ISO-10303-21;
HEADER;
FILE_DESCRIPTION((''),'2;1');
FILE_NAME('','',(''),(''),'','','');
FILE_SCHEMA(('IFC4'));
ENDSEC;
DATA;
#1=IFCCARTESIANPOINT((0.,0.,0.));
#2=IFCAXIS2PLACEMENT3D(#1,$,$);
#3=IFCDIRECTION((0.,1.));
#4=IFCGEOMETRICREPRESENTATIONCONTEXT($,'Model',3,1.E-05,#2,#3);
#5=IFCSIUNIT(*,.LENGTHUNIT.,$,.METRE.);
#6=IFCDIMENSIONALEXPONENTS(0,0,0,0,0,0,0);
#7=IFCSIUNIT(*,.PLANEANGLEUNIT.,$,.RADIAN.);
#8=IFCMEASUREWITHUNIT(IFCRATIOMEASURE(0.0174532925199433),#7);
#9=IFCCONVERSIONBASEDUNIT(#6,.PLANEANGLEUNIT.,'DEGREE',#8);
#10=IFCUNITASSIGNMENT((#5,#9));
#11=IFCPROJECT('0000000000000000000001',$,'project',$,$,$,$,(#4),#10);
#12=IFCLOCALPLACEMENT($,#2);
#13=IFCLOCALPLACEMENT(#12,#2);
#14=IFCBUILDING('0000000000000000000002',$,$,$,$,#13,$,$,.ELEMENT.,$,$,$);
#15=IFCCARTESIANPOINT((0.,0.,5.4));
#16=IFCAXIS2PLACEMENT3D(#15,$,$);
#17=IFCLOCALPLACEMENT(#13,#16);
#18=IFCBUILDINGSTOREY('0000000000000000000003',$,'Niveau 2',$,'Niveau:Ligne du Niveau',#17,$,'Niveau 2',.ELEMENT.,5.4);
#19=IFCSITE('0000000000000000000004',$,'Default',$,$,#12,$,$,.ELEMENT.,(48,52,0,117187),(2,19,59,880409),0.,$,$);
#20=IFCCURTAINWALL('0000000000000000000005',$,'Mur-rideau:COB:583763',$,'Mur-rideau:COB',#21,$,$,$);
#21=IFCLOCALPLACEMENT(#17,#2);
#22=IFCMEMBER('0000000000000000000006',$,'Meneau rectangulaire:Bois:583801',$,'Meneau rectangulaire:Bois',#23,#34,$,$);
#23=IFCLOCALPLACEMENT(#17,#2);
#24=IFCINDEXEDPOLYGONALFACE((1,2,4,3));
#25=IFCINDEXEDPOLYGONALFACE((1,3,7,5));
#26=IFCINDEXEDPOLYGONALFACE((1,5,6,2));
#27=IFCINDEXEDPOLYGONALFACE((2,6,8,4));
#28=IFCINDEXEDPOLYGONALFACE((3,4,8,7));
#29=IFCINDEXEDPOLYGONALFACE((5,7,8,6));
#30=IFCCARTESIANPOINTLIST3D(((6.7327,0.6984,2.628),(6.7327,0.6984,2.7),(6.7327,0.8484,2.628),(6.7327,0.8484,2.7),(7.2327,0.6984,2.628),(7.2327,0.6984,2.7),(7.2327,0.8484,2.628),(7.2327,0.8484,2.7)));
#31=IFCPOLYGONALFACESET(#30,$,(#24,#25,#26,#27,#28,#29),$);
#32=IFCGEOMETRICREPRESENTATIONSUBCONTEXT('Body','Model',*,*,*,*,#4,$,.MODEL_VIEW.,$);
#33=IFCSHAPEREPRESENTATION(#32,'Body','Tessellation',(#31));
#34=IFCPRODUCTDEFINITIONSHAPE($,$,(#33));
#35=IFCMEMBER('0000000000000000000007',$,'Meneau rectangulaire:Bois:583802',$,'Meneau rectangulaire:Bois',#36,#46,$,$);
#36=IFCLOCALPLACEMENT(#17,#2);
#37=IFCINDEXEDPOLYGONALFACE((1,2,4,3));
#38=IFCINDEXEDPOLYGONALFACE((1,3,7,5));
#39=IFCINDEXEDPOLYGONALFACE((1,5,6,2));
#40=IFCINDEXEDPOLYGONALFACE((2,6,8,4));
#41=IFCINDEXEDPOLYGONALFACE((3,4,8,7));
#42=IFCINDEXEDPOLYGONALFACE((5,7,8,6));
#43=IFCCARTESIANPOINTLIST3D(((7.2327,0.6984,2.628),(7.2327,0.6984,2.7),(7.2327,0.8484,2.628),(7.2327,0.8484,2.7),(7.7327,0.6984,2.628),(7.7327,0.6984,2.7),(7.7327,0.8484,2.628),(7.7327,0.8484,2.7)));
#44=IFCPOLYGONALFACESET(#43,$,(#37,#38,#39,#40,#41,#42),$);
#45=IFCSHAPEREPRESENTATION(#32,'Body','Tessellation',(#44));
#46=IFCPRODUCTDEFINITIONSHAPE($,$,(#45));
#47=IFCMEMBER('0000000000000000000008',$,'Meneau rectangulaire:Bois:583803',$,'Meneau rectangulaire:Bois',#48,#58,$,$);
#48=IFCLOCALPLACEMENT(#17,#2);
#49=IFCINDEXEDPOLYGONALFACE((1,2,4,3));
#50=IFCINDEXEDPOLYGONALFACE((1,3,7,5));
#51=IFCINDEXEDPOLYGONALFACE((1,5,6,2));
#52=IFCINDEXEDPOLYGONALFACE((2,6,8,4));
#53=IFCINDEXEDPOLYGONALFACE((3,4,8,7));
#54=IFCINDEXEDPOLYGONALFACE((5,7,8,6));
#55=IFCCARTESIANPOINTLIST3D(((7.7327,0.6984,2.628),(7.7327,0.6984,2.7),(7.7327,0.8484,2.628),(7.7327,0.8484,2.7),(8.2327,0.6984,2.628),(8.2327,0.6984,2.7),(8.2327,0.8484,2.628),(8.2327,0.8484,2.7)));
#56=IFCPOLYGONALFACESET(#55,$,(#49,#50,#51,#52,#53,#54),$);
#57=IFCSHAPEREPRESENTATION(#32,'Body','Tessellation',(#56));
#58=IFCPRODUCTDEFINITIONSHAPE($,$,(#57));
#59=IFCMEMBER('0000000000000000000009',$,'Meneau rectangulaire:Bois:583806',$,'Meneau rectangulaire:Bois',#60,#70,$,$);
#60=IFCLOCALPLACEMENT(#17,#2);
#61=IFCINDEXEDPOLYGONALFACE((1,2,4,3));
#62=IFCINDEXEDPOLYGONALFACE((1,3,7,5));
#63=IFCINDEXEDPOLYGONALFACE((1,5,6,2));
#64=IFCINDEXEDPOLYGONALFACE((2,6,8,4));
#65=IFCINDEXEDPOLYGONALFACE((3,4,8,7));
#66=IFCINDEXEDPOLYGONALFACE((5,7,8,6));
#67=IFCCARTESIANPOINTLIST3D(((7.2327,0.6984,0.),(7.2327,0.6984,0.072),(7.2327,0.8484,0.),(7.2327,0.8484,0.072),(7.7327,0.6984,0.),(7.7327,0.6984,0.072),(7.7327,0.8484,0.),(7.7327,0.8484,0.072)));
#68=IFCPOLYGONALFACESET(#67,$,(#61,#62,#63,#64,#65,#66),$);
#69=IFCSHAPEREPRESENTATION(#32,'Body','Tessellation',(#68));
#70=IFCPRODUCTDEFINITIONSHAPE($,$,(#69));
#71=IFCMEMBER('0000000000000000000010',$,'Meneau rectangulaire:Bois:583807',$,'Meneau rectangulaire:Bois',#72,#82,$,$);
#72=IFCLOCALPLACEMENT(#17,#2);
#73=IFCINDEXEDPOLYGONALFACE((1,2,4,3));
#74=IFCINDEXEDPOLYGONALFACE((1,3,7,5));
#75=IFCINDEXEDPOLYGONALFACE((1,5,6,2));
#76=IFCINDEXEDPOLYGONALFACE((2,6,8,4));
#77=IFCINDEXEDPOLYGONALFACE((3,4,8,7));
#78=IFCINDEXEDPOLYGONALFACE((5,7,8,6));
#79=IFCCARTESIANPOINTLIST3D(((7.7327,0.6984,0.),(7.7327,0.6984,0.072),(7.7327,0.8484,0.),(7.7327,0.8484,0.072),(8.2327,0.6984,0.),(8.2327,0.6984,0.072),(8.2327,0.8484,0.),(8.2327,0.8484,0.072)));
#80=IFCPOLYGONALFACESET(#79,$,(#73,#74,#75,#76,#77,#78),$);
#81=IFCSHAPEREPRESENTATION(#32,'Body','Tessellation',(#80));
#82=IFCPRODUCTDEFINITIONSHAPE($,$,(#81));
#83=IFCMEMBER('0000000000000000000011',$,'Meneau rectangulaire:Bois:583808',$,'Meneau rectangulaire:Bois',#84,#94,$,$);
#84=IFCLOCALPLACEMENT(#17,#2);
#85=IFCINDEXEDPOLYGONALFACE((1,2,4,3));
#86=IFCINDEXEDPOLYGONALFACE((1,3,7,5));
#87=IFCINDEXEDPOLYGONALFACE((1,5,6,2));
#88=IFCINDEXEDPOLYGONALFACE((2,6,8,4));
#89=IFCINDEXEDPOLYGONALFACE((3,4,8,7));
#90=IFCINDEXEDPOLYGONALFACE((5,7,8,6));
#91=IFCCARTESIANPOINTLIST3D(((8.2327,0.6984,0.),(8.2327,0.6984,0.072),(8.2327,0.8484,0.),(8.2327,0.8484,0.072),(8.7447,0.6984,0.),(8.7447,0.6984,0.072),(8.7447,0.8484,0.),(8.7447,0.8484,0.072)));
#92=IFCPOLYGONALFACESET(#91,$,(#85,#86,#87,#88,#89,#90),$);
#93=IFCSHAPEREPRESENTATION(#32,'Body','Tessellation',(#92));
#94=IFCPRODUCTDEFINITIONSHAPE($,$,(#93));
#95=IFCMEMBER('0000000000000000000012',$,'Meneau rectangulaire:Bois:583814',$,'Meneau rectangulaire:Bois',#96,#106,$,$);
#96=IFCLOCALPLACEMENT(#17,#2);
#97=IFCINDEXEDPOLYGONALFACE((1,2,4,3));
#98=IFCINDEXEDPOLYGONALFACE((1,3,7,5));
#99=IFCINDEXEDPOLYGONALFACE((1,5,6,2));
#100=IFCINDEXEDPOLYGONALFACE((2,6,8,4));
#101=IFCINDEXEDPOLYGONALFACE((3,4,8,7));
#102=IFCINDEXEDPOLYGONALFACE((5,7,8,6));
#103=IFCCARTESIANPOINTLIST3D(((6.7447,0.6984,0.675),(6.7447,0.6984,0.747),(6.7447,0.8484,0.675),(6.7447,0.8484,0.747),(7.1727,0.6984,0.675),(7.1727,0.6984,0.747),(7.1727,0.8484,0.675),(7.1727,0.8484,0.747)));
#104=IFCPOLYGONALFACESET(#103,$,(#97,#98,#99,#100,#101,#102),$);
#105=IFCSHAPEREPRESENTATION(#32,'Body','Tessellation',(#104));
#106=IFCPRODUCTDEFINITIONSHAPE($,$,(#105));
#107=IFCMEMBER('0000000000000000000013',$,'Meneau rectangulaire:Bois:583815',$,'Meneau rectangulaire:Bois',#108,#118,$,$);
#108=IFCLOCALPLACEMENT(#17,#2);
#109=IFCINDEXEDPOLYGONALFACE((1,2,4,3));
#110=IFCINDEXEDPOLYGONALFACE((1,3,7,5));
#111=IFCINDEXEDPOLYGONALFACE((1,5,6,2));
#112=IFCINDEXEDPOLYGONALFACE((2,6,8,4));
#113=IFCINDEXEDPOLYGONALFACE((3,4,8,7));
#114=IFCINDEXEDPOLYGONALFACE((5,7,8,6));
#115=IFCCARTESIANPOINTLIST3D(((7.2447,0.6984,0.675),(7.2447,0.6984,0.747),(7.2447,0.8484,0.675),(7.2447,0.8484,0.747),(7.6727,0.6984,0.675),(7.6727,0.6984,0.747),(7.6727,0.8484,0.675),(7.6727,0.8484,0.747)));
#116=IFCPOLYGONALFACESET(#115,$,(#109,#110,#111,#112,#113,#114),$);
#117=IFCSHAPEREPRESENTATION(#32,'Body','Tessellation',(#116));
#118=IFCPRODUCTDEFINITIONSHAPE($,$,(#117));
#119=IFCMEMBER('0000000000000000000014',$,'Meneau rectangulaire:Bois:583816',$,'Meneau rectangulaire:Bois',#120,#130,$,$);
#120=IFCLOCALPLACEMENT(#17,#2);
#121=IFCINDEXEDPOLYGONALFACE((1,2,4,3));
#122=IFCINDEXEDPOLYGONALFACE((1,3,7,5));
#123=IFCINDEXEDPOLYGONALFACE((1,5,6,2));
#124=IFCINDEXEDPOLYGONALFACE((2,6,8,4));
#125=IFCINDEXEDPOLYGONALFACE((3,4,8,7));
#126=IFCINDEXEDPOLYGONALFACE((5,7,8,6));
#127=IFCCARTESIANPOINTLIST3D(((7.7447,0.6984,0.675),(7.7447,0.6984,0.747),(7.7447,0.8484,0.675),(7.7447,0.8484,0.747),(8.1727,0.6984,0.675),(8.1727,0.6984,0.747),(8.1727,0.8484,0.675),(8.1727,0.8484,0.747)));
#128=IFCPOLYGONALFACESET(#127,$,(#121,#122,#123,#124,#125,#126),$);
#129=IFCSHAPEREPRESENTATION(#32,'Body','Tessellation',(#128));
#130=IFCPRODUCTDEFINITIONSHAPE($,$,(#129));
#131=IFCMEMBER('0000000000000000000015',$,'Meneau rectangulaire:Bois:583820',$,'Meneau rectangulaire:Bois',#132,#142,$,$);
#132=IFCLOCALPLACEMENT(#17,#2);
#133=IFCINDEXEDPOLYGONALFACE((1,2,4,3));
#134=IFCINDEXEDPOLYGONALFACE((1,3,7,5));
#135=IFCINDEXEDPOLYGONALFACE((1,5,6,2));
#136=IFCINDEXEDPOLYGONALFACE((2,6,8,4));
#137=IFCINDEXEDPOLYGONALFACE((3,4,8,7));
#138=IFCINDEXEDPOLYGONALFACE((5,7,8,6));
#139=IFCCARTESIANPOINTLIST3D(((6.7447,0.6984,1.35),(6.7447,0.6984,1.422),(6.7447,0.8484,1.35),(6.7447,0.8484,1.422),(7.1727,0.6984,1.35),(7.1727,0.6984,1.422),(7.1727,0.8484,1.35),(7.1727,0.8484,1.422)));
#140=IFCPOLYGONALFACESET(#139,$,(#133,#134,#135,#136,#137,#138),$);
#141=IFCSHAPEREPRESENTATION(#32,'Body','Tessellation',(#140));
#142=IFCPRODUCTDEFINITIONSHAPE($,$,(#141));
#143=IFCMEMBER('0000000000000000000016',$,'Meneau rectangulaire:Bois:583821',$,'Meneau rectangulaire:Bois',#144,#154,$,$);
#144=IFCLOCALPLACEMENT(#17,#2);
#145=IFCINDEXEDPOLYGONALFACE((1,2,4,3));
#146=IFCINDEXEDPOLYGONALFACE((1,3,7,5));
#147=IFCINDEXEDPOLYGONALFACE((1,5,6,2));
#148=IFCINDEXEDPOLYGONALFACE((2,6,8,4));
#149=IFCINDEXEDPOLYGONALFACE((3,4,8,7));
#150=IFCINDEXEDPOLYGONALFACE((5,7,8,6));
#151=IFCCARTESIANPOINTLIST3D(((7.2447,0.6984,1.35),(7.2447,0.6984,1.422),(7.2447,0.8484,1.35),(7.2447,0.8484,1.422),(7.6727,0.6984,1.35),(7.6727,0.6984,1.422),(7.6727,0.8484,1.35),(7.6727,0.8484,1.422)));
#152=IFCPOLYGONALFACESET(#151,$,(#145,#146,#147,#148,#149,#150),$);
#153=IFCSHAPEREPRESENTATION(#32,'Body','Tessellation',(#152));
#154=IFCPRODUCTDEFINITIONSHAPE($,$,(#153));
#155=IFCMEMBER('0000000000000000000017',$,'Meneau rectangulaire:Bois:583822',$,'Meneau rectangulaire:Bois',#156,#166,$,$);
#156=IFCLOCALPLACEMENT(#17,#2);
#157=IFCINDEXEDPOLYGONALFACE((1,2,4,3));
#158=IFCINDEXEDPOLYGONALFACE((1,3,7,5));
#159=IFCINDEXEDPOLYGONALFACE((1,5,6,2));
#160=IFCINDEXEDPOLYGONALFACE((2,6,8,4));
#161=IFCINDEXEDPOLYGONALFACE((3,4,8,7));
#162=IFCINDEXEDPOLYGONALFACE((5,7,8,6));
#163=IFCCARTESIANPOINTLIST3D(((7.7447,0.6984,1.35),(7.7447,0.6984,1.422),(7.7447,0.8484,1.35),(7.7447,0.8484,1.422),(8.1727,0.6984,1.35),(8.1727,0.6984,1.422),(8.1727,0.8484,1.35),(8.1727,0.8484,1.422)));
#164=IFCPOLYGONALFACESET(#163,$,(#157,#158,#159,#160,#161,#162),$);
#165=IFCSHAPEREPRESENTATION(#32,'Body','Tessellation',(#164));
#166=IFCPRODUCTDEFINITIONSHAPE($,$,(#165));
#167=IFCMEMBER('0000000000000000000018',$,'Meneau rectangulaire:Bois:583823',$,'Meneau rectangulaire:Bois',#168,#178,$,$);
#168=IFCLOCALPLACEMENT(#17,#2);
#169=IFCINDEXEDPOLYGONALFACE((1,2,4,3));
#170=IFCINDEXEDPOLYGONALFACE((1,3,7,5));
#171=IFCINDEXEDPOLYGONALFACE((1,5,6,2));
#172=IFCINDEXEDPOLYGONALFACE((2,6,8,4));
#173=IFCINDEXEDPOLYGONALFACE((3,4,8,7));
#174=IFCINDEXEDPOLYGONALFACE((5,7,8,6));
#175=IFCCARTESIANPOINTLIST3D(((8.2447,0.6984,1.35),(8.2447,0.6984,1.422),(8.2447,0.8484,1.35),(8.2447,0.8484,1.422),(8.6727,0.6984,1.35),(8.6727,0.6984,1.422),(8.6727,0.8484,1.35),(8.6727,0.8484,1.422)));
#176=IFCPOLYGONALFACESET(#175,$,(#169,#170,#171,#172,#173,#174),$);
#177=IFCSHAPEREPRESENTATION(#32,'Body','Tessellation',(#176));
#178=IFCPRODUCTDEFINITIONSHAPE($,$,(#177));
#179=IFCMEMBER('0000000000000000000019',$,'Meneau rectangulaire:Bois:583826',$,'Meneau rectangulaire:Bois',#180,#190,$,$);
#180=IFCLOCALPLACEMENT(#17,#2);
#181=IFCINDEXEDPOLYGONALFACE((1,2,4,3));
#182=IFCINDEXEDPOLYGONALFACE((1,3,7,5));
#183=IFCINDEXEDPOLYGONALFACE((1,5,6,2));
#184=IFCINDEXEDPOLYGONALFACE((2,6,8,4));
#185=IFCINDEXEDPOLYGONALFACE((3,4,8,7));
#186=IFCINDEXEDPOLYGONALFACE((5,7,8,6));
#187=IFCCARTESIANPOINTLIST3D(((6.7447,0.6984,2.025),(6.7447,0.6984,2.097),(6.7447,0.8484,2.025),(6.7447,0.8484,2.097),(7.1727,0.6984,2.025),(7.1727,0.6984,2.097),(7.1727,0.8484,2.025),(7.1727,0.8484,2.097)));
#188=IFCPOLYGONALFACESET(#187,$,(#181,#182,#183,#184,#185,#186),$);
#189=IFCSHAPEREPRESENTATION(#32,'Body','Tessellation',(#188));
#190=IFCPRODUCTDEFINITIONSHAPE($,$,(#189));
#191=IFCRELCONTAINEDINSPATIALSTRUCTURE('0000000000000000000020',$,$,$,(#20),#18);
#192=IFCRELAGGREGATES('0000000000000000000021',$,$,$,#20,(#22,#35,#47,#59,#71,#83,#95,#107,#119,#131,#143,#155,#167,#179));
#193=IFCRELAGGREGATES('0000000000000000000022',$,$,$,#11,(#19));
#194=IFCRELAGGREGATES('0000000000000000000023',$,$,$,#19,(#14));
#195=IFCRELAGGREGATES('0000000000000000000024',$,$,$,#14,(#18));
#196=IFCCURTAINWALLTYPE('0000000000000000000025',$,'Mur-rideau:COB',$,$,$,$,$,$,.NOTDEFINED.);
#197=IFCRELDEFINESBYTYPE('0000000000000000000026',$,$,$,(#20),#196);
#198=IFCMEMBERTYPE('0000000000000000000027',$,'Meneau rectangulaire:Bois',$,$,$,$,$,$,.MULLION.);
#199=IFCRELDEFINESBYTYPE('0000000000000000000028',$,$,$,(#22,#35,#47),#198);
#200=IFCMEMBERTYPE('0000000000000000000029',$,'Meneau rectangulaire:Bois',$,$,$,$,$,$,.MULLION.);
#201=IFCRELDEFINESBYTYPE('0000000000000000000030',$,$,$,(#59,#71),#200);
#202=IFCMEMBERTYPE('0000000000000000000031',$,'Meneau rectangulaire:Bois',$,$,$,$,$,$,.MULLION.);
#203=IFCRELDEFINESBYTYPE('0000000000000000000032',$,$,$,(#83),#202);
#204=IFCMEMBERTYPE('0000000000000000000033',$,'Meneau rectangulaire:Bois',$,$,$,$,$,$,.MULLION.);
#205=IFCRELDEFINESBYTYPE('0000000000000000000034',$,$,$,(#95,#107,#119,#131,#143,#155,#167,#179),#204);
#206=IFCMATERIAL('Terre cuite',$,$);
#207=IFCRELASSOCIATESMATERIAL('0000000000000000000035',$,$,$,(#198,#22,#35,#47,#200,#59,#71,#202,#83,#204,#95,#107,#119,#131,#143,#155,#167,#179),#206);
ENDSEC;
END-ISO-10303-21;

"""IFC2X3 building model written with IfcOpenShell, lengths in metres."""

from ifc_helpers import new_model, entity, si_unit, converted_unit, direction, frame, origin, origin_2d_with_axis, place, context, subcontext, project, spatial, rectangle, extrude, source, transform, mapped, material, type_object, type_shapes, element, aggregate, save


model = new_model("IFC2X3")

# Units and contexts
model_context = context("Model", 3, precision=1e-05, world=origin(), true_north=direction((0.0, 1.0)))
body_context = subcontext(model_context, "Body", "Model", "MODEL_VIEW")
ifc_project = project(units=[si_unit("LENGTHUNIT", "METRE"), converted_unit("PLANEANGLEUNIT", "DEGREE", entity("IfcRatioMeasure", 0.0174532925199433), si_unit("PLANEANGLEUNIT", "RADIAN"), dimensions=[0, 0, 0, 0, 0, 0, 0])], contexts=[model_context])

# Site, building, storey
site_placement = place(None, origin())
site = spatial("IfcSite", under=ifc_project, at=site_placement, Name="Default", CompositionType="ELEMENT", RefLatitude=(48, 52, 0, 117187), RefLongitude=(2, 19, 59, 880409), RefElevation=0.0)
building_placement = place(site_placement, origin())
building = spatial("IfcBuilding", under=site, at=building_placement, CompositionType="ELEMENT")
storey_placement = place(building_placement, frame((0.0, 0.0, 5.4)))
storey = spatial("IfcBuildingStorey", under=building, at=storey_placement, Name="Niveau 2", ObjectType="Niveau:Ligne du Niveau", LongName="Niveau 2", CompositionType="ELEMENT", Elevation=5.4)

# Curtain wall, members
curtain_wall_type_1 = type_object("IfcCurtainWallType", Name="Mur-rideau:COB", PredefinedType="NOTDEFINED")
curtain_wall_1_placement = place(storey_placement, frame((0.0, 0.0, -5.4)))
curtain_wall_1 = element("IfcCurtainWall", 1, at=curtain_wall_1_placement, inside=storey, type_object=curtain_wall_type_1, Name="Mur-rideau:COB:583763", ObjectType="Mur-rideau:COB")
ifc_material_1 = material(Name="Terre cuite")
member_type_1 = type_object("IfcMemberType", Name="Meneau rectangulaire:Bois", PredefinedType="MULLION", material=ifc_material_1)
shared_shape_1 = source(origin(), body_context, "Body", "SweptSolid", [
    extrude(rectangle(XDim=0.15, YDim=0.072, at=origin_2d_with_axis()), frame((-0.036, 0.0, -0.5), z_axis=(0.0, 0.0, 1.0), x_axis=(0.0, -1.0, 0.0)), (0.0, 0.0, 1.0), 0.5),
])
type_shapes(member_type_1, [shared_shape_1])
member_1_placement = place(storey_placement, frame((7.2327, 0.7734, 2.7), z_axis=(1.0, 0.0, 0.0), x_axis=(0.0, 0.0, 1.0)))
member_1 = element("IfcMember", 2, at=member_1_placement, type_object=member_type_1, material=ifc_material_1, Name="Meneau rectangulaire:Bois:583801", ObjectType="Meneau rectangulaire:Bois", context=body_context, shape_type="MappedRepresentation", body=[
    mapped(shared_shape_1, transform((0.0, 0.0, 0.0), scale=1.0)),
])
member_2_placement = place(storey_placement, frame((7.7327, 0.7734, 2.7), z_axis=(1.0, 0.0, 0.0), x_axis=(0.0, 0.0, 1.0)))
member_2 = element("IfcMember", 3, at=member_2_placement, type_object=member_type_1, material=ifc_material_1, Name="Meneau rectangulaire:Bois:583802", ObjectType="Meneau rectangulaire:Bois", context=body_context, shape_type="MappedRepresentation", body=[
    mapped(shared_shape_1, transform((0.0, 0.0, 0.0), scale=1.0)),
])
member_3_placement = place(storey_placement, frame((8.2327, 0.7734, 2.7), z_axis=(1.0, 0.0, 0.0), x_axis=(0.0, 0.0, 1.0)))
member_3 = element("IfcMember", 4, at=member_3_placement, type_object=member_type_1, material=ifc_material_1, Name="Meneau rectangulaire:Bois:583803", ObjectType="Meneau rectangulaire:Bois", context=body_context, shape_type="MappedRepresentation", body=[
    mapped(shared_shape_1, transform((0.0, 0.0, 0.0), scale=1.0)),
])
member_type_2 = type_object("IfcMemberType", Name="Meneau rectangulaire:Bois", PredefinedType="MULLION", material=ifc_material_1)
shared_shape_2 = source(origin(), body_context, "Body", "SweptSolid", [
    extrude(rectangle(XDim=0.15, YDim=0.072, at=origin_2d_with_axis()), frame((-0.036, 0.0, -0.5), z_axis=(0.0, 0.0, 1.0), x_axis=(0.0, -1.0, 0.0)), (0.0, 0.0, 1.0), 0.5),
])
type_shapes(member_type_2, [shared_shape_2])
member_4_placement = place(storey_placement, frame((7.2327, 0.7734, 0.0), z_axis=(-1.0, 0.0, 0.0), x_axis=(0.0, 0.0, -1.0)))
member_4 = element("IfcMember", 5, at=member_4_placement, type_object=member_type_2, material=ifc_material_1, Name="Meneau rectangulaire:Bois:583806", ObjectType="Meneau rectangulaire:Bois", context=body_context, shape_type="MappedRepresentation", body=[
    mapped(shared_shape_2, transform((0.0, 0.0, 0.0), scale=1.0)),
])
member_5_placement = place(storey_placement, frame((7.7327, 0.7734, 0.0), z_axis=(-1.0, 0.0, 0.0), x_axis=(0.0, 0.0, -1.0)))
member_5 = element("IfcMember", 6, at=member_5_placement, type_object=member_type_2, material=ifc_material_1, Name="Meneau rectangulaire:Bois:583807", ObjectType="Meneau rectangulaire:Bois", context=body_context, shape_type="MappedRepresentation", body=[
    mapped(shared_shape_2, transform((0.0, 0.0, 0.0), scale=1.0)),
])
member_type_3 = type_object("IfcMemberType", Name="Meneau rectangulaire:Bois", PredefinedType="MULLION", material=ifc_material_1)
shared_shape_3 = source(origin(), body_context, "Body", "SweptSolid", [
    extrude(rectangle(XDim=0.15, YDim=0.072, at=origin_2d_with_axis()), frame((-0.036, 0.0, -0.512), z_axis=(0.0, 0.0, 1.0), x_axis=(0.0, -1.0, 0.0)), (0.0, 0.0, 1.0), 0.512),
])
type_shapes(member_type_3, [shared_shape_3])
member_6_placement = place(storey_placement, frame((8.2327, 0.7734, 0.0), z_axis=(-1.0, 0.0, 0.0), x_axis=(0.0, 0.0, -1.0)))
member_6 = element("IfcMember", 7, at=member_6_placement, type_object=member_type_3, material=ifc_material_1, Name="Meneau rectangulaire:Bois:583808", ObjectType="Meneau rectangulaire:Bois", context=body_context, shape_type="MappedRepresentation", body=[
    mapped(shared_shape_3, transform((0.0, 0.0, 0.0), scale=1.0)),
])
member_type_4 = type_object("IfcMemberType", Name="Meneau rectangulaire:Bois", PredefinedType="MULLION", material=ifc_material_1)
shared_shape_4 = source(origin(), body_context, "Body", "SweptSolid", [
    extrude(rectangle(XDim=0.15, YDim=0.072, at=origin_2d_with_axis()), frame((-0.024, 0.0, -0.428), z_axis=(0.0, 0.0, 1.0), x_axis=(0.0, -1.0, 0.0)), (0.0, 0.0, 1.0), 0.428),
])
type_shapes(member_type_4, [shared_shape_4])
member_7_placement = place(storey_placement, frame((7.1727, 0.7734, 0.735), z_axis=(1.0, 0.0, 0.0), x_axis=(0.0, 0.0, 1.0)))
member_7 = element("IfcMember", 8, at=member_7_placement, type_object=member_type_4, material=ifc_material_1, Name="Meneau rectangulaire:Bois:583814", ObjectType="Meneau rectangulaire:Bois", context=body_context, shape_type="MappedRepresentation", body=[
    mapped(shared_shape_4, transform((0.0, 0.0, 0.0), scale=1.0)),
])
member_8_placement = place(storey_placement, frame((7.6727, 0.7734, 0.735), z_axis=(1.0, 0.0, 0.0), x_axis=(0.0, 0.0, 1.0)))
member_8 = element("IfcMember", 9, at=member_8_placement, type_object=member_type_4, material=ifc_material_1, Name="Meneau rectangulaire:Bois:583815", ObjectType="Meneau rectangulaire:Bois", context=body_context, shape_type="MappedRepresentation", body=[
    mapped(shared_shape_4, transform((0.0, 0.0, 0.0), scale=1.0)),
])
member_9_placement = place(storey_placement, frame((8.1727, 0.7734, 0.735), z_axis=(1.0, 0.0, 0.0), x_axis=(0.0, 0.0, 1.0)))
member_9 = element("IfcMember", 10, at=member_9_placement, type_object=member_type_4, material=ifc_material_1, Name="Meneau rectangulaire:Bois:583816", ObjectType="Meneau rectangulaire:Bois", context=body_context, shape_type="MappedRepresentation", body=[
    mapped(shared_shape_4, transform((0.0, 0.0, 0.0), scale=1.0)),
])
member_10_placement = place(storey_placement, frame((7.1727, 0.7734, 1.41), z_axis=(1.0, 0.0, 0.0), x_axis=(0.0, 0.0, 1.0)))
member_10 = element("IfcMember", 11, at=member_10_placement, type_object=member_type_4, material=ifc_material_1, Name="Meneau rectangulaire:Bois:583820", ObjectType="Meneau rectangulaire:Bois", context=body_context, shape_type="MappedRepresentation", body=[
    mapped(shared_shape_4, transform((0.0, 0.0, 0.0), scale=1.0)),
])
member_11_placement = place(storey_placement, frame((7.6727, 0.7734, 1.41), z_axis=(1.0, 0.0, 0.0), x_axis=(0.0, 0.0, 1.0)))
member_11 = element("IfcMember", 12, at=member_11_placement, type_object=member_type_4, material=ifc_material_1, Name="Meneau rectangulaire:Bois:583821", ObjectType="Meneau rectangulaire:Bois", context=body_context, shape_type="MappedRepresentation", body=[
    mapped(shared_shape_4, transform((0.0, 0.0, 0.0), scale=1.0)),
])
member_12_placement = place(storey_placement, frame((8.1727, 0.7734, 1.41), z_axis=(1.0, 0.0, 0.0), x_axis=(0.0, 0.0, 1.0)))
member_12 = element("IfcMember", 13, at=member_12_placement, type_object=member_type_4, material=ifc_material_1, Name="Meneau rectangulaire:Bois:583822", ObjectType="Meneau rectangulaire:Bois", context=body_context, shape_type="MappedRepresentation", body=[
    mapped(shared_shape_4, transform((0.0, 0.0, 0.0), scale=1.0)),
])
member_13_placement = place(storey_placement, frame((8.6727, 0.7734, 1.41), z_axis=(1.0, 0.0, 0.0), x_axis=(0.0, 0.0, 1.0)))
member_13 = element("IfcMember", 14, at=member_13_placement, type_object=member_type_4, material=ifc_material_1, Name="Meneau rectangulaire:Bois:583823", ObjectType="Meneau rectangulaire:Bois", context=body_context, shape_type="MappedRepresentation", body=[
    mapped(shared_shape_4, transform((0.0, 0.0, 0.0), scale=1.0)),
])
member_14_placement = place(storey_placement, frame((7.1727, 0.7734, 2.085), z_axis=(1.0, 0.0, 0.0), x_axis=(0.0, 0.0, 1.0)))
member_14 = element("IfcMember", 15, at=member_14_placement, type_object=member_type_4, material=ifc_material_1, Name="Meneau rectangulaire:Bois:583826", ObjectType="Meneau rectangulaire:Bois", context=body_context, shape_type="MappedRepresentation", body=[
    mapped(shared_shape_4, transform((0.0, 0.0, 0.0), scale=1.0)),
])
aggregate(curtain_wall_1, [member_1, member_2, member_3, member_4, member_5, member_6, member_7, member_8, member_9, member_10, member_11, member_12, member_13, member_14])

save(model, "model.ifc")
